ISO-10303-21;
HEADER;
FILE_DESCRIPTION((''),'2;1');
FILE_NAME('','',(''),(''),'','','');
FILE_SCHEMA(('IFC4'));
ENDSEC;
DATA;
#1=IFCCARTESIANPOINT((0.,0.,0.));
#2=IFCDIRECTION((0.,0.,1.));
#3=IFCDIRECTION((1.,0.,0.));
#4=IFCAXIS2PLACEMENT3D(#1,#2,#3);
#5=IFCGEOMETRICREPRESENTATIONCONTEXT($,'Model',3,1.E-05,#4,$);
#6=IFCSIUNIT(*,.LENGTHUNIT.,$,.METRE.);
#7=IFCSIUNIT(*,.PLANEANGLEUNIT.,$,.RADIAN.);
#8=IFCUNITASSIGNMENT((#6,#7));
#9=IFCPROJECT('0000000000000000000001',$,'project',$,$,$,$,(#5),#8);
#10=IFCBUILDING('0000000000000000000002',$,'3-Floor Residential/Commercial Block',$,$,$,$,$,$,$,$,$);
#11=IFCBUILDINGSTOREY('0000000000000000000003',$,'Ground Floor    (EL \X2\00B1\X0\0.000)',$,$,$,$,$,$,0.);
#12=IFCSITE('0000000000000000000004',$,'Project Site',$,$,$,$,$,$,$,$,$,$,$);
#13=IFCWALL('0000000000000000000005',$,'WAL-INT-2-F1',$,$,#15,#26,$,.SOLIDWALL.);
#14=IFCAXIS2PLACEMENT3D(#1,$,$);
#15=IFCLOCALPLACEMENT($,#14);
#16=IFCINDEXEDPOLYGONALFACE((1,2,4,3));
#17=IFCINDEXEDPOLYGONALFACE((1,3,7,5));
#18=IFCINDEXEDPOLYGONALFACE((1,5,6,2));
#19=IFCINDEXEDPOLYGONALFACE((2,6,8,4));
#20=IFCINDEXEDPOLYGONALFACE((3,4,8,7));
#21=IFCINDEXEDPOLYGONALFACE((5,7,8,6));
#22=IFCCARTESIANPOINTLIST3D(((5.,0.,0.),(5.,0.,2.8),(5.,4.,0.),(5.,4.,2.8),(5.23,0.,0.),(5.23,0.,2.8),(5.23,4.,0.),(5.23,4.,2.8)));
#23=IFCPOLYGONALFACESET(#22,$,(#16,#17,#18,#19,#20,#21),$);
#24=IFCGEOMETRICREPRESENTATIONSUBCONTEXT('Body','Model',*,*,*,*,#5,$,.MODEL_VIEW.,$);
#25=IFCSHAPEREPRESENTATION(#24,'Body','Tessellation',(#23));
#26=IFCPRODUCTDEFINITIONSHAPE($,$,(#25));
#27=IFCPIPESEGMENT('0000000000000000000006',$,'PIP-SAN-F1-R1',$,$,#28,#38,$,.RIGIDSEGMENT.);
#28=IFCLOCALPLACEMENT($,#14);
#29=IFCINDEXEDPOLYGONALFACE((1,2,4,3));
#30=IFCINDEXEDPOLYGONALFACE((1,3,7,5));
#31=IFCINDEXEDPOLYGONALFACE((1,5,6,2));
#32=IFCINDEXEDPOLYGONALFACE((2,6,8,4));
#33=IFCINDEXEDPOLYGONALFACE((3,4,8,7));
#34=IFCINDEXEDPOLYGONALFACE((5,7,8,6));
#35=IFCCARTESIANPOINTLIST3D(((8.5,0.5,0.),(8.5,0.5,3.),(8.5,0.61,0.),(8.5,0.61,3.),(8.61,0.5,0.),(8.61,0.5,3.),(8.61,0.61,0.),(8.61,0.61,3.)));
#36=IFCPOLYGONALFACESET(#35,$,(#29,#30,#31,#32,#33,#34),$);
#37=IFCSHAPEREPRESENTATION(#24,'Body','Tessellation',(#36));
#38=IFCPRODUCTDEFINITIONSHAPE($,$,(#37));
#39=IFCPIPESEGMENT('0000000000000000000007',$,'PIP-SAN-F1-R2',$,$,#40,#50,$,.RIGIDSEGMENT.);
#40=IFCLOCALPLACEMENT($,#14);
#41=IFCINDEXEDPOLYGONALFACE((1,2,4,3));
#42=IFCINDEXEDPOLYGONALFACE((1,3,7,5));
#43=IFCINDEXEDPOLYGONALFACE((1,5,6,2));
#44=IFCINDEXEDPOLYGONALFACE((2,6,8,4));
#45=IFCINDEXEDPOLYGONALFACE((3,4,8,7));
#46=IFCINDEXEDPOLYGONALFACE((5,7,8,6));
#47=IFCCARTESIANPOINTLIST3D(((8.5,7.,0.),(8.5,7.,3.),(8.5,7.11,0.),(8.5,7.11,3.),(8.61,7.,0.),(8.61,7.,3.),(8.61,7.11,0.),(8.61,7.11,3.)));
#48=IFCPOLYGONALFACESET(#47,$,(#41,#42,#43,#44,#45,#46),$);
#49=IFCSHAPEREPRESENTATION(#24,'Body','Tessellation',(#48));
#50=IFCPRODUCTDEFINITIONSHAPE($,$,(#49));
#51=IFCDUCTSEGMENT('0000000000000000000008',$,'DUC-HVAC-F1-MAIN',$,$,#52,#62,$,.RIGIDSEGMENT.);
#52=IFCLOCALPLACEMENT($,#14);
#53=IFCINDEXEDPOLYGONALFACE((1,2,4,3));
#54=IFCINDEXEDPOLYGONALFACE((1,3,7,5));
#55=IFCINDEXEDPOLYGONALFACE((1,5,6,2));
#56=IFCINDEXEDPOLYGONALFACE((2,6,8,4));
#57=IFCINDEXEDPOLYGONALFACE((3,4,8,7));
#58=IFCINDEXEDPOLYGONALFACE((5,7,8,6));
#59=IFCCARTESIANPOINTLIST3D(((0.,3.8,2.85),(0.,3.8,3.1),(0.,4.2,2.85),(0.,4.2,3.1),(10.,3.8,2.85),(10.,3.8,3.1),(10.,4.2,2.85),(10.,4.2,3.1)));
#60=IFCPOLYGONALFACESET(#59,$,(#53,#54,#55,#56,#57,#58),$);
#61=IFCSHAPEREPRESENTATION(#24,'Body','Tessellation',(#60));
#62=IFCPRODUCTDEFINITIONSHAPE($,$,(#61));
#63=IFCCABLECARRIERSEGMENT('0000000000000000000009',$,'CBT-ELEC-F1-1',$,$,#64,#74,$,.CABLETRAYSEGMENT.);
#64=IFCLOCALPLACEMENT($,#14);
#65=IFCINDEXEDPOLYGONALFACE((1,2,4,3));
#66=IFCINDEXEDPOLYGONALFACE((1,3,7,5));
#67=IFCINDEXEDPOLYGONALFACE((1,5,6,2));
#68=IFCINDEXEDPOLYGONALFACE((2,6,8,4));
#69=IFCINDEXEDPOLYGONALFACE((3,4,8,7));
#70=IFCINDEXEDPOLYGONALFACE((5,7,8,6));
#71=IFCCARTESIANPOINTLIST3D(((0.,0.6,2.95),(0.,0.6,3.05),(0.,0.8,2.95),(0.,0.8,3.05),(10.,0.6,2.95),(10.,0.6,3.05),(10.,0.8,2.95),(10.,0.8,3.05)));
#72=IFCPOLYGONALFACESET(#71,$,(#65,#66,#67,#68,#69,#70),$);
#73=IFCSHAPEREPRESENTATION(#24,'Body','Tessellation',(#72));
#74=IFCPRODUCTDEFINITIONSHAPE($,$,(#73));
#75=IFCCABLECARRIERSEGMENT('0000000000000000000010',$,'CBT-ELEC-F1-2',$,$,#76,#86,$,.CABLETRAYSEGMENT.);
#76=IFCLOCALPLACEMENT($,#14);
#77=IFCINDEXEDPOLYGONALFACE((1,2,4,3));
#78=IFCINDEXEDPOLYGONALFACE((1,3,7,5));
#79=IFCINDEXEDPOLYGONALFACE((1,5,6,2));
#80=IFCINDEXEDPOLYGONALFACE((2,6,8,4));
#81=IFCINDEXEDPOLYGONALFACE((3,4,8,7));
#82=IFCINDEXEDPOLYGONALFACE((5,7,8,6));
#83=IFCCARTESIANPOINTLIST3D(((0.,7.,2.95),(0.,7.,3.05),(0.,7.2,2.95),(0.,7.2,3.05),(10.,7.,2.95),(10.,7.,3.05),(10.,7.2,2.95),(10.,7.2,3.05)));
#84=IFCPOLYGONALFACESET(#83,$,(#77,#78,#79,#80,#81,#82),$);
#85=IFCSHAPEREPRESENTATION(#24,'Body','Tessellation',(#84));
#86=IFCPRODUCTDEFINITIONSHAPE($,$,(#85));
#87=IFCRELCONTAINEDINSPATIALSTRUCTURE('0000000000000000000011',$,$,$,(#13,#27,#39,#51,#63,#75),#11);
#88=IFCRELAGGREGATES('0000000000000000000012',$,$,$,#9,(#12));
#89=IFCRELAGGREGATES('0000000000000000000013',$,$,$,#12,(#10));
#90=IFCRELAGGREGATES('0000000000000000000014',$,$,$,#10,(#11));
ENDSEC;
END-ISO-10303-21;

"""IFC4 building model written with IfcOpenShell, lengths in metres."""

from ifc_helpers import new_model, si_unit, frame, frame_2d, origin_with_axes, place, context, subcontext, project, spatial, rectangle, extrude, element, save


model = new_model("IFC4")

# Units and contexts
model_context = context("Model", 3, precision=1e-05, world=origin_with_axes())
body_context = subcontext(model_context, "Body", "Model", "MODEL_VIEW")
ifc_project = project(units=[si_unit("LENGTHUNIT", "METRE"), si_unit("PLANEANGLEUNIT", "RADIAN")], contexts=[model_context])

# Site, building, storey
site = spatial("IfcSite", under=ifc_project, Name="Project Site")
building = spatial("IfcBuilding", under=site, Name="3-Floor Residential/Commercial Block")
storey = spatial("IfcBuildingStorey", under=building, Name="Ground Floor    (EL ±0.000)", Elevation=0.0)

# Wall
wall_1_placement = place(None, frame((5.0, 0.0, 0.0), z_axis=(0.0, 0.0, 1.0), x_axis=(1.0, 0.0, 0.0)))
element("IfcWall", 1, at=wall_1_placement, inside=storey, Name="WAL-INT-2-F1", PredefinedType="SOLIDWALL", context=body_context, shape_type="SweptSolid", body=[
    extrude(rectangle(XDim=0.23, YDim=4.0, at=frame_2d((0.115, 2.0))), origin_with_axes(), (0.0, 0.0, 1.0), 2.8),
])

# Pipe segments
for number, where, z_axis, x_axis, name in (
    (2, (8.5, 0.5, 0.0), (0.0, 0.0, 1.0), (1.0, 0.0, 0.0), "PIP-SAN-F1-R1"),
    (3, (8.5, 7.0, 0.0), (0.0, 0.0, 1.0), (1.0, 0.0, 0.0), "PIP-SAN-F1-R2"),
):
    element("IfcPipeSegment", number, at=place(None, frame(where, z_axis=z_axis, x_axis=x_axis)), inside=storey, Name=name, PredefinedType="RIGIDSEGMENT", context=body_context, shape_type="SweptSolid", body=[
        extrude(rectangle(XDim=0.11, YDim=0.11, at=frame_2d((0.055, 0.055))), origin_with_axes(), (0.0, 0.0, 1.0), 3.0),
    ])

# Duct segment
duct_segment_placement = place(None, frame((0.0, 3.8, 2.85), z_axis=(0.0, 0.0, 1.0), x_axis=(1.0, 0.0, 0.0)))
element("IfcDuctSegment", 4, at=duct_segment_placement, inside=storey, Name="DUC-HVAC-F1-MAIN", PredefinedType="RIGIDSEGMENT", context=body_context, shape_type="SweptSolid", body=[
    extrude(rectangle(XDim=10.0, YDim=0.4, at=frame_2d((5.0, 0.2))), origin_with_axes(), (0.0, 0.0, 1.0), 0.25),
])

# Cable carrier segments
for number, where, z_axis, x_axis, name in (
    (5, (0.0, 0.6, 2.95), (0.0, 0.0, 1.0), (1.0, 0.0, 0.0), "CBT-ELEC-F1-1"),
    (6, (0.0, 7.0, 2.95), (0.0, 0.0, 1.0), (1.0, 0.0, 0.0), "CBT-ELEC-F1-2"),
):
    element("IfcCableCarrierSegment", number, at=place(None, frame(where, z_axis=z_axis, x_axis=x_axis)), inside=storey, Name=name, PredefinedType="CABLETRAYSEGMENT", context=body_context, shape_type="SweptSolid", body=[
        extrude(rectangle(XDim=10.0, YDim=0.2, at=frame_2d((5.0, 0.1))), origin_with_axes(), (0.0, 0.0, 1.0), 0.1),
    ])

save(model, "model.ifc")
